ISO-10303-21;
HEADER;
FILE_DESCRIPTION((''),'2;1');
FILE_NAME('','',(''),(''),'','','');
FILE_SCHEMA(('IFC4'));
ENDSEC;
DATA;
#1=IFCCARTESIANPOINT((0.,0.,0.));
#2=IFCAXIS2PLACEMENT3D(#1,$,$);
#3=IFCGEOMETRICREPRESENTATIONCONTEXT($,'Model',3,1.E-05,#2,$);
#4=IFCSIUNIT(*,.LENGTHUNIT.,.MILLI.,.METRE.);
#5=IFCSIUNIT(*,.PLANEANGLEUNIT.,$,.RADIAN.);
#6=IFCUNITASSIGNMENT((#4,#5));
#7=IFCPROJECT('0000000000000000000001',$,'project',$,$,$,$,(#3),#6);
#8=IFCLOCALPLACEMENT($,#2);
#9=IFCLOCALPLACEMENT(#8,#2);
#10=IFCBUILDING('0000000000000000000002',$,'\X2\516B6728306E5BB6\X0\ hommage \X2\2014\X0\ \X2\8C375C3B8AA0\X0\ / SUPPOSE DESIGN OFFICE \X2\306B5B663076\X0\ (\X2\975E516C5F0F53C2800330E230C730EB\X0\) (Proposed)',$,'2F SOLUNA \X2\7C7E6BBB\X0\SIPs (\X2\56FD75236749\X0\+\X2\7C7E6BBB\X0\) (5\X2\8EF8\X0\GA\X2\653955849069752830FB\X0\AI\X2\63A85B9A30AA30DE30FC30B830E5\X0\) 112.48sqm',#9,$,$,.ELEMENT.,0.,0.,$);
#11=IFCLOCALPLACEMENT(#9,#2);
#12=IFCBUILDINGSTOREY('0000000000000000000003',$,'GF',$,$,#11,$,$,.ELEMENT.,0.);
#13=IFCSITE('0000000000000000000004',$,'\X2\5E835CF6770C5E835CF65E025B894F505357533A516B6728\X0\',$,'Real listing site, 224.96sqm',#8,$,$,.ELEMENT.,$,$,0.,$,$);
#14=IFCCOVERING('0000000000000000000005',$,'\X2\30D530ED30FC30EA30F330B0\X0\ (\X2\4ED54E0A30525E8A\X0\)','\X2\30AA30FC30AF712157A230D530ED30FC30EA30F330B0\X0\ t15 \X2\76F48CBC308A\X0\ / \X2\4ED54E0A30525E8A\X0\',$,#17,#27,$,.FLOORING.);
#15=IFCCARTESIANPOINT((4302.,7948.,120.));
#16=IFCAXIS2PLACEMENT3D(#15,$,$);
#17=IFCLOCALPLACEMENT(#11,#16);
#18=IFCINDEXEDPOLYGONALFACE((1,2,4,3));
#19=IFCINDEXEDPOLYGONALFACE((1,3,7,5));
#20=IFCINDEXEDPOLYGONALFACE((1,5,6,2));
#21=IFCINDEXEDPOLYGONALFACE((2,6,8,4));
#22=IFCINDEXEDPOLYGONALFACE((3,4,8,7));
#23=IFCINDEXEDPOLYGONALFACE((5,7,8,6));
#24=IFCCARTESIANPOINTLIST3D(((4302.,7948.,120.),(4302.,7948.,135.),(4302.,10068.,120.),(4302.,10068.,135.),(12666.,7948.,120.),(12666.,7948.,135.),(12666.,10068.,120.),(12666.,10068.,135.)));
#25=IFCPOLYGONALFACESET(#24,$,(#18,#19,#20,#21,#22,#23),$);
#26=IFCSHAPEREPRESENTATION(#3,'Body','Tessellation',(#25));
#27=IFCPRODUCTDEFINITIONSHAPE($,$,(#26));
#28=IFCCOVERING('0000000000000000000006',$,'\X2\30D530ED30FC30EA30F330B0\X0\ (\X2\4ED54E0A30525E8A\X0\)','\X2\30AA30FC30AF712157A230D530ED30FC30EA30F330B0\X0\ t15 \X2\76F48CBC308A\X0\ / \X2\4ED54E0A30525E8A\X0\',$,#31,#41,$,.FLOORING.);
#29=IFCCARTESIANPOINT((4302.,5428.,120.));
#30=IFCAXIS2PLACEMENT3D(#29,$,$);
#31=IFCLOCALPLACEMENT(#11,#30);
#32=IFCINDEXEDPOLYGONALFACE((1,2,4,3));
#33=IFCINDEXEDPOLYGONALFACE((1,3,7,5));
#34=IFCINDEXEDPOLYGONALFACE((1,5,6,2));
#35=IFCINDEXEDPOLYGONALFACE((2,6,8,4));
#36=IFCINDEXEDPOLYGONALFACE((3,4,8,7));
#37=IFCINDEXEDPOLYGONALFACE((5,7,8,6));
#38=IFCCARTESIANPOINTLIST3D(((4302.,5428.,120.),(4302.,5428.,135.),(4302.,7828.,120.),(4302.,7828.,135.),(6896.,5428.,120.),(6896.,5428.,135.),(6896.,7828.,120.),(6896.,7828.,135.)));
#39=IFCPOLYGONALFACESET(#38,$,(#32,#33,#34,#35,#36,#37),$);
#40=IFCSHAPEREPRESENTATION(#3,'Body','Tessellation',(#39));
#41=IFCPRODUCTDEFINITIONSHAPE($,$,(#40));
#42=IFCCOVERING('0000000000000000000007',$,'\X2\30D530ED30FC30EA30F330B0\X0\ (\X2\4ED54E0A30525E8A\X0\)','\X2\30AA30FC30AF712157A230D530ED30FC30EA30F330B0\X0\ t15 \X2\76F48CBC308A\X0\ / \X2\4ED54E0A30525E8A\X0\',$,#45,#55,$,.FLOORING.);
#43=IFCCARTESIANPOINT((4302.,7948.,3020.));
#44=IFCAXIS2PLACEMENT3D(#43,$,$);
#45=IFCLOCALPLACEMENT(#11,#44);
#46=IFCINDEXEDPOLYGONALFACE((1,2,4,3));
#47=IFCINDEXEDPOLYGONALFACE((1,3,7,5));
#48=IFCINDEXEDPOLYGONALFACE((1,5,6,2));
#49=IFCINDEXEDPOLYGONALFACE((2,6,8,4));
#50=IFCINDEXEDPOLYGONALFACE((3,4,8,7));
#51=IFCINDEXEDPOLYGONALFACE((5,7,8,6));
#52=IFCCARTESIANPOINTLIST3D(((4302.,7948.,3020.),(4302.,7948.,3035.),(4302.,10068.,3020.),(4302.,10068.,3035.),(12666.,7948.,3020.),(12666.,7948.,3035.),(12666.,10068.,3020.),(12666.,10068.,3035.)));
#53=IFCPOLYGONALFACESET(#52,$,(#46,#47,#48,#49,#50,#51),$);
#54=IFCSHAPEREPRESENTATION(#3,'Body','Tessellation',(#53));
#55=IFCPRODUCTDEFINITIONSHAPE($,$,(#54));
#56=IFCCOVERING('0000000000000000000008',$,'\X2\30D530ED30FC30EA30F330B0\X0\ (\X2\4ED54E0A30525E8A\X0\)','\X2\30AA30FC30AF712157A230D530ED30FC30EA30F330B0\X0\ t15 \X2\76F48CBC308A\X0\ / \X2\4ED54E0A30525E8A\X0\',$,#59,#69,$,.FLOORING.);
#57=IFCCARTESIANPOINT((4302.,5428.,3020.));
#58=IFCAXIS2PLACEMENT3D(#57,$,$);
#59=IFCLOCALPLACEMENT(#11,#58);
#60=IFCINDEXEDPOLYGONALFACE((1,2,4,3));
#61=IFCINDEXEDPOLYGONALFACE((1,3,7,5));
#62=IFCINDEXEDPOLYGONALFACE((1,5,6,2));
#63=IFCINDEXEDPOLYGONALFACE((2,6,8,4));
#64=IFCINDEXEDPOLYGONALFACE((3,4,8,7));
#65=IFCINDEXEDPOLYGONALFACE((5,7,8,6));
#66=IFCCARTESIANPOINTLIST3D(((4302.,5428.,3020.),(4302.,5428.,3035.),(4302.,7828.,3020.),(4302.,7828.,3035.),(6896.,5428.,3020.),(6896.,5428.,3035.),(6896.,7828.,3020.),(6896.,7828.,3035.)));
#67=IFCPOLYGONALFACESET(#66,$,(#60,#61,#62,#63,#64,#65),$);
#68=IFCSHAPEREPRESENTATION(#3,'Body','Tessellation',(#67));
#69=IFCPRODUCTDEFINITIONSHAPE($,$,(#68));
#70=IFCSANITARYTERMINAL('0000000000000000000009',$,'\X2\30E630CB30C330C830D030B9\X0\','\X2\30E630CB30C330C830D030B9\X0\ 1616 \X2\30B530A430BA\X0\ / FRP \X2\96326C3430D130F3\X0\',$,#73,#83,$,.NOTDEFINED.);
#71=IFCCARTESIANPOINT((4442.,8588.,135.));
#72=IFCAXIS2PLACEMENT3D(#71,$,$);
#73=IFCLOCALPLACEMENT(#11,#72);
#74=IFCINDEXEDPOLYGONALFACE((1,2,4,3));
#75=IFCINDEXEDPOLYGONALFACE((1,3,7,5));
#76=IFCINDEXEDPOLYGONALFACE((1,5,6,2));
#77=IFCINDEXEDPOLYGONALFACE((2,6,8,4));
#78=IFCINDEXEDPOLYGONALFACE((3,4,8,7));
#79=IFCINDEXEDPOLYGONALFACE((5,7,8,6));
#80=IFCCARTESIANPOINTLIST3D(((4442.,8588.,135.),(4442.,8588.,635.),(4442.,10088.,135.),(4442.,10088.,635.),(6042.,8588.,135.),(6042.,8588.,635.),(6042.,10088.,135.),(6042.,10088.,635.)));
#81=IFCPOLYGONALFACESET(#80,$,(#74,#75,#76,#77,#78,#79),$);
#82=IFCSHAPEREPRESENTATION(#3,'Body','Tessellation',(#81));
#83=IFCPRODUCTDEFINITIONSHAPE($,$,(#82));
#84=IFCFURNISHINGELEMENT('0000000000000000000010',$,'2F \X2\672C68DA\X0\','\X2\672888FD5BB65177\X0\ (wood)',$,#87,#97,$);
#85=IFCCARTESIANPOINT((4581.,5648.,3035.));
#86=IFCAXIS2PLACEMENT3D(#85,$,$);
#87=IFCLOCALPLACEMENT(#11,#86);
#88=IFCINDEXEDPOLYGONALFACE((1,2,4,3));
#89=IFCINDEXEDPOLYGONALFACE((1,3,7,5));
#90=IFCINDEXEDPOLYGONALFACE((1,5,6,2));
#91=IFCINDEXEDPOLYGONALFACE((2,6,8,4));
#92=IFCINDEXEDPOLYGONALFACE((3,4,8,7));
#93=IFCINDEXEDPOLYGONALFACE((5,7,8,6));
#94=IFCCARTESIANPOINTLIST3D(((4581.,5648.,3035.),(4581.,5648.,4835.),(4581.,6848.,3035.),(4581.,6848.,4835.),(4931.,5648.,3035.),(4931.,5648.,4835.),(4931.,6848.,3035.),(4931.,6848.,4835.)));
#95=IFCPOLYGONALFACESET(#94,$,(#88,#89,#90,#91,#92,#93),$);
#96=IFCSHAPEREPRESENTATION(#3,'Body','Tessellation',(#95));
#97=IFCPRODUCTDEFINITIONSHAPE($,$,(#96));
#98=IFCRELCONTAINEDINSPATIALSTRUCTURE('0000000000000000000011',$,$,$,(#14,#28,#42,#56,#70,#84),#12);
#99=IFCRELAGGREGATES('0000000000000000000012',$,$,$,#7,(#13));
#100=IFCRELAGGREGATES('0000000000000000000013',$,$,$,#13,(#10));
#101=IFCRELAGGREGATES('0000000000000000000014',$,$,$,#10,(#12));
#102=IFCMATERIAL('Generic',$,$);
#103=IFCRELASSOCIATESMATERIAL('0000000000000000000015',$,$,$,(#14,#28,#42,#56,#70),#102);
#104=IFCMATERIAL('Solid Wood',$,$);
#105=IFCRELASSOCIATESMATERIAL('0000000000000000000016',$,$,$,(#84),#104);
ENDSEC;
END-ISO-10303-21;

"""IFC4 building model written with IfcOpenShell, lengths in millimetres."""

from ifc_helpers import new_model, si_unit, frame, frame_2d, origin, place, context, project, spatial, rectangle, extrude, material, element, save


model = new_model("IFC4")

# Units and contexts
model_context = context("Model", 3, precision=1e-05, world=origin())
ifc_project = project(units=[si_unit("LENGTHUNIT", "METRE", prefix="MILLI"), si_unit("PLANEANGLEUNIT", "RADIAN")], contexts=[model_context])

# Site, building, storey
site_placement = place(None, origin())
site = spatial("IfcSite", under=ifc_project, at=site_placement, Name="広島県広島市安佐南区八木", ObjectType="Real listing site, 224.96sqm", CompositionType="ELEMENT", RefElevation=0.0)
building_placement = place(site_placement, origin())
building = spatial("IfcBuilding", under=site, at=building_placement, Name="八木の家 hommage — 谷尻誠 / SUPPOSE DESIGN OFFICE に学ぶ (非公式参考モデル) (Proposed)", ObjectType="2F SOLUNA 籾殻SIPs (国産杉+籾殻) (5軸GA改善適用・AI推定オマージュ) 112.48sqm", CompositionType="ELEMENT", ElevationOfRefHeight=0.0, ElevationOfTerrain=0.0)
storey_placement = place(building_placement, origin())
storey = spatial("IfcBuildingStorey", under=building, at=storey_placement, Name="GF", CompositionType="ELEMENT", Elevation=0.0)

# Shared definitions
ifc_material_1 = material(Name="Solid Wood")

# Coverings
ifc_material_2 = material(Name="Generic")
covering_1_placement = place(storey_placement, frame((4302.0, 7948.0, 120.0)))
element("IfcCovering", 1, at=covering_1_placement, inside=storey, material=ifc_material_2, Name="フローリング (仕上げ床)", Description="オーク無垢フローリング t15 直貼り / 仕上げ床", PredefinedType="FLOORING", context=model_context, shape_type="SweptSolid", body=[
    extrude(rectangle(XDim=8364.0, YDim=2120.0, at=frame_2d((4182.0, 1060.0))), frame((4302.0, 7948.0, 120.0)), (0.0, 0.0, 1.0), 15.0),
])
covering_2_placement = place(storey_placement, frame((4302.0, 5428.0, 120.0)))
element("IfcCovering", 2, at=covering_2_placement, inside=storey, material=ifc_material_2, Name="フローリング (仕上げ床)", Description="オーク無垢フローリング t15 直貼り / 仕上げ床", PredefinedType="FLOORING", context=model_context, shape_type="SweptSolid", body=[
    extrude(rectangle(XDim=2594.0, YDim=2400.0, at=frame_2d((1297.0, 1200.0))), frame((4302.0, 5428.0, 120.0)), (0.0, 0.0, 1.0), 15.0),
])
covering_3_placement = place(storey_placement, frame((4302.0, 7948.0, 3020.0)))
element("IfcCovering", 3, at=covering_3_placement, inside=storey, material=ifc_material_2, Name="フローリング (仕上げ床)", Description="オーク無垢フローリング t15 直貼り / 仕上げ床", PredefinedType="FLOORING", context=model_context, shape_type="SweptSolid", body=[
    extrude(rectangle(XDim=8364.0, YDim=2120.0, at=frame_2d((4182.0, 1060.0))), frame((4302.0, 7948.0, 3020.0)), (0.0, 0.0, 1.0), 15.0),
])
covering_4_placement = place(storey_placement, frame((4302.0, 5428.0, 3020.0)))
element("IfcCovering", 4, at=covering_4_placement, inside=storey, material=ifc_material_2, Name="フローリング (仕上げ床)", Description="オーク無垢フローリング t15 直貼り / 仕上げ床", PredefinedType="FLOORING", context=model_context, shape_type="SweptSolid", body=[
    extrude(rectangle(XDim=2594.0, YDim=2400.0, at=frame_2d((1297.0, 1200.0))), frame((4302.0, 5428.0, 3020.0)), (0.0, 0.0, 1.0), 15.0),
])

# Sanitary terminal
sanitary_terminal_placement = place(storey_placement, frame((4442.0, 8588.0, 135.0)))
element("IfcSanitaryTerminal", 5, at=sanitary_terminal_placement, inside=storey, material=ifc_material_2, Name="ユニットバス", Description="ユニットバス 1616 サイズ / FRP 防水パン", PredefinedType="NOTDEFINED", context=model_context, shape_type="SweptSolid", body=[
    extrude(rectangle(XDim=1600.0, YDim=1500.0, at=frame_2d((800.0, 750.0))), frame((4442.0, 8588.0, 135.0)), (0.0, 0.0, 1.0), 500.0),
])

# Furnishing element
furnishing_placement = place(storey_placement, frame((4581.0, 5648.0, 3035.0)))
element("IfcFurnishingElement", 6, at=furnishing_placement, inside=storey, material=ifc_material_1, Name="2F 本棚", Description="木製家具 (wood)", context=model_context, shape_type="SweptSolid", body=[
    extrude(rectangle(XDim=350.0, YDim=1200.0, at=frame_2d((175.0, 600.0))), frame((4581.0, 5648.0, 3035.0)), (0.0, 0.0, 1.0), 1800.0),
])

save(model, "model.ifc")
